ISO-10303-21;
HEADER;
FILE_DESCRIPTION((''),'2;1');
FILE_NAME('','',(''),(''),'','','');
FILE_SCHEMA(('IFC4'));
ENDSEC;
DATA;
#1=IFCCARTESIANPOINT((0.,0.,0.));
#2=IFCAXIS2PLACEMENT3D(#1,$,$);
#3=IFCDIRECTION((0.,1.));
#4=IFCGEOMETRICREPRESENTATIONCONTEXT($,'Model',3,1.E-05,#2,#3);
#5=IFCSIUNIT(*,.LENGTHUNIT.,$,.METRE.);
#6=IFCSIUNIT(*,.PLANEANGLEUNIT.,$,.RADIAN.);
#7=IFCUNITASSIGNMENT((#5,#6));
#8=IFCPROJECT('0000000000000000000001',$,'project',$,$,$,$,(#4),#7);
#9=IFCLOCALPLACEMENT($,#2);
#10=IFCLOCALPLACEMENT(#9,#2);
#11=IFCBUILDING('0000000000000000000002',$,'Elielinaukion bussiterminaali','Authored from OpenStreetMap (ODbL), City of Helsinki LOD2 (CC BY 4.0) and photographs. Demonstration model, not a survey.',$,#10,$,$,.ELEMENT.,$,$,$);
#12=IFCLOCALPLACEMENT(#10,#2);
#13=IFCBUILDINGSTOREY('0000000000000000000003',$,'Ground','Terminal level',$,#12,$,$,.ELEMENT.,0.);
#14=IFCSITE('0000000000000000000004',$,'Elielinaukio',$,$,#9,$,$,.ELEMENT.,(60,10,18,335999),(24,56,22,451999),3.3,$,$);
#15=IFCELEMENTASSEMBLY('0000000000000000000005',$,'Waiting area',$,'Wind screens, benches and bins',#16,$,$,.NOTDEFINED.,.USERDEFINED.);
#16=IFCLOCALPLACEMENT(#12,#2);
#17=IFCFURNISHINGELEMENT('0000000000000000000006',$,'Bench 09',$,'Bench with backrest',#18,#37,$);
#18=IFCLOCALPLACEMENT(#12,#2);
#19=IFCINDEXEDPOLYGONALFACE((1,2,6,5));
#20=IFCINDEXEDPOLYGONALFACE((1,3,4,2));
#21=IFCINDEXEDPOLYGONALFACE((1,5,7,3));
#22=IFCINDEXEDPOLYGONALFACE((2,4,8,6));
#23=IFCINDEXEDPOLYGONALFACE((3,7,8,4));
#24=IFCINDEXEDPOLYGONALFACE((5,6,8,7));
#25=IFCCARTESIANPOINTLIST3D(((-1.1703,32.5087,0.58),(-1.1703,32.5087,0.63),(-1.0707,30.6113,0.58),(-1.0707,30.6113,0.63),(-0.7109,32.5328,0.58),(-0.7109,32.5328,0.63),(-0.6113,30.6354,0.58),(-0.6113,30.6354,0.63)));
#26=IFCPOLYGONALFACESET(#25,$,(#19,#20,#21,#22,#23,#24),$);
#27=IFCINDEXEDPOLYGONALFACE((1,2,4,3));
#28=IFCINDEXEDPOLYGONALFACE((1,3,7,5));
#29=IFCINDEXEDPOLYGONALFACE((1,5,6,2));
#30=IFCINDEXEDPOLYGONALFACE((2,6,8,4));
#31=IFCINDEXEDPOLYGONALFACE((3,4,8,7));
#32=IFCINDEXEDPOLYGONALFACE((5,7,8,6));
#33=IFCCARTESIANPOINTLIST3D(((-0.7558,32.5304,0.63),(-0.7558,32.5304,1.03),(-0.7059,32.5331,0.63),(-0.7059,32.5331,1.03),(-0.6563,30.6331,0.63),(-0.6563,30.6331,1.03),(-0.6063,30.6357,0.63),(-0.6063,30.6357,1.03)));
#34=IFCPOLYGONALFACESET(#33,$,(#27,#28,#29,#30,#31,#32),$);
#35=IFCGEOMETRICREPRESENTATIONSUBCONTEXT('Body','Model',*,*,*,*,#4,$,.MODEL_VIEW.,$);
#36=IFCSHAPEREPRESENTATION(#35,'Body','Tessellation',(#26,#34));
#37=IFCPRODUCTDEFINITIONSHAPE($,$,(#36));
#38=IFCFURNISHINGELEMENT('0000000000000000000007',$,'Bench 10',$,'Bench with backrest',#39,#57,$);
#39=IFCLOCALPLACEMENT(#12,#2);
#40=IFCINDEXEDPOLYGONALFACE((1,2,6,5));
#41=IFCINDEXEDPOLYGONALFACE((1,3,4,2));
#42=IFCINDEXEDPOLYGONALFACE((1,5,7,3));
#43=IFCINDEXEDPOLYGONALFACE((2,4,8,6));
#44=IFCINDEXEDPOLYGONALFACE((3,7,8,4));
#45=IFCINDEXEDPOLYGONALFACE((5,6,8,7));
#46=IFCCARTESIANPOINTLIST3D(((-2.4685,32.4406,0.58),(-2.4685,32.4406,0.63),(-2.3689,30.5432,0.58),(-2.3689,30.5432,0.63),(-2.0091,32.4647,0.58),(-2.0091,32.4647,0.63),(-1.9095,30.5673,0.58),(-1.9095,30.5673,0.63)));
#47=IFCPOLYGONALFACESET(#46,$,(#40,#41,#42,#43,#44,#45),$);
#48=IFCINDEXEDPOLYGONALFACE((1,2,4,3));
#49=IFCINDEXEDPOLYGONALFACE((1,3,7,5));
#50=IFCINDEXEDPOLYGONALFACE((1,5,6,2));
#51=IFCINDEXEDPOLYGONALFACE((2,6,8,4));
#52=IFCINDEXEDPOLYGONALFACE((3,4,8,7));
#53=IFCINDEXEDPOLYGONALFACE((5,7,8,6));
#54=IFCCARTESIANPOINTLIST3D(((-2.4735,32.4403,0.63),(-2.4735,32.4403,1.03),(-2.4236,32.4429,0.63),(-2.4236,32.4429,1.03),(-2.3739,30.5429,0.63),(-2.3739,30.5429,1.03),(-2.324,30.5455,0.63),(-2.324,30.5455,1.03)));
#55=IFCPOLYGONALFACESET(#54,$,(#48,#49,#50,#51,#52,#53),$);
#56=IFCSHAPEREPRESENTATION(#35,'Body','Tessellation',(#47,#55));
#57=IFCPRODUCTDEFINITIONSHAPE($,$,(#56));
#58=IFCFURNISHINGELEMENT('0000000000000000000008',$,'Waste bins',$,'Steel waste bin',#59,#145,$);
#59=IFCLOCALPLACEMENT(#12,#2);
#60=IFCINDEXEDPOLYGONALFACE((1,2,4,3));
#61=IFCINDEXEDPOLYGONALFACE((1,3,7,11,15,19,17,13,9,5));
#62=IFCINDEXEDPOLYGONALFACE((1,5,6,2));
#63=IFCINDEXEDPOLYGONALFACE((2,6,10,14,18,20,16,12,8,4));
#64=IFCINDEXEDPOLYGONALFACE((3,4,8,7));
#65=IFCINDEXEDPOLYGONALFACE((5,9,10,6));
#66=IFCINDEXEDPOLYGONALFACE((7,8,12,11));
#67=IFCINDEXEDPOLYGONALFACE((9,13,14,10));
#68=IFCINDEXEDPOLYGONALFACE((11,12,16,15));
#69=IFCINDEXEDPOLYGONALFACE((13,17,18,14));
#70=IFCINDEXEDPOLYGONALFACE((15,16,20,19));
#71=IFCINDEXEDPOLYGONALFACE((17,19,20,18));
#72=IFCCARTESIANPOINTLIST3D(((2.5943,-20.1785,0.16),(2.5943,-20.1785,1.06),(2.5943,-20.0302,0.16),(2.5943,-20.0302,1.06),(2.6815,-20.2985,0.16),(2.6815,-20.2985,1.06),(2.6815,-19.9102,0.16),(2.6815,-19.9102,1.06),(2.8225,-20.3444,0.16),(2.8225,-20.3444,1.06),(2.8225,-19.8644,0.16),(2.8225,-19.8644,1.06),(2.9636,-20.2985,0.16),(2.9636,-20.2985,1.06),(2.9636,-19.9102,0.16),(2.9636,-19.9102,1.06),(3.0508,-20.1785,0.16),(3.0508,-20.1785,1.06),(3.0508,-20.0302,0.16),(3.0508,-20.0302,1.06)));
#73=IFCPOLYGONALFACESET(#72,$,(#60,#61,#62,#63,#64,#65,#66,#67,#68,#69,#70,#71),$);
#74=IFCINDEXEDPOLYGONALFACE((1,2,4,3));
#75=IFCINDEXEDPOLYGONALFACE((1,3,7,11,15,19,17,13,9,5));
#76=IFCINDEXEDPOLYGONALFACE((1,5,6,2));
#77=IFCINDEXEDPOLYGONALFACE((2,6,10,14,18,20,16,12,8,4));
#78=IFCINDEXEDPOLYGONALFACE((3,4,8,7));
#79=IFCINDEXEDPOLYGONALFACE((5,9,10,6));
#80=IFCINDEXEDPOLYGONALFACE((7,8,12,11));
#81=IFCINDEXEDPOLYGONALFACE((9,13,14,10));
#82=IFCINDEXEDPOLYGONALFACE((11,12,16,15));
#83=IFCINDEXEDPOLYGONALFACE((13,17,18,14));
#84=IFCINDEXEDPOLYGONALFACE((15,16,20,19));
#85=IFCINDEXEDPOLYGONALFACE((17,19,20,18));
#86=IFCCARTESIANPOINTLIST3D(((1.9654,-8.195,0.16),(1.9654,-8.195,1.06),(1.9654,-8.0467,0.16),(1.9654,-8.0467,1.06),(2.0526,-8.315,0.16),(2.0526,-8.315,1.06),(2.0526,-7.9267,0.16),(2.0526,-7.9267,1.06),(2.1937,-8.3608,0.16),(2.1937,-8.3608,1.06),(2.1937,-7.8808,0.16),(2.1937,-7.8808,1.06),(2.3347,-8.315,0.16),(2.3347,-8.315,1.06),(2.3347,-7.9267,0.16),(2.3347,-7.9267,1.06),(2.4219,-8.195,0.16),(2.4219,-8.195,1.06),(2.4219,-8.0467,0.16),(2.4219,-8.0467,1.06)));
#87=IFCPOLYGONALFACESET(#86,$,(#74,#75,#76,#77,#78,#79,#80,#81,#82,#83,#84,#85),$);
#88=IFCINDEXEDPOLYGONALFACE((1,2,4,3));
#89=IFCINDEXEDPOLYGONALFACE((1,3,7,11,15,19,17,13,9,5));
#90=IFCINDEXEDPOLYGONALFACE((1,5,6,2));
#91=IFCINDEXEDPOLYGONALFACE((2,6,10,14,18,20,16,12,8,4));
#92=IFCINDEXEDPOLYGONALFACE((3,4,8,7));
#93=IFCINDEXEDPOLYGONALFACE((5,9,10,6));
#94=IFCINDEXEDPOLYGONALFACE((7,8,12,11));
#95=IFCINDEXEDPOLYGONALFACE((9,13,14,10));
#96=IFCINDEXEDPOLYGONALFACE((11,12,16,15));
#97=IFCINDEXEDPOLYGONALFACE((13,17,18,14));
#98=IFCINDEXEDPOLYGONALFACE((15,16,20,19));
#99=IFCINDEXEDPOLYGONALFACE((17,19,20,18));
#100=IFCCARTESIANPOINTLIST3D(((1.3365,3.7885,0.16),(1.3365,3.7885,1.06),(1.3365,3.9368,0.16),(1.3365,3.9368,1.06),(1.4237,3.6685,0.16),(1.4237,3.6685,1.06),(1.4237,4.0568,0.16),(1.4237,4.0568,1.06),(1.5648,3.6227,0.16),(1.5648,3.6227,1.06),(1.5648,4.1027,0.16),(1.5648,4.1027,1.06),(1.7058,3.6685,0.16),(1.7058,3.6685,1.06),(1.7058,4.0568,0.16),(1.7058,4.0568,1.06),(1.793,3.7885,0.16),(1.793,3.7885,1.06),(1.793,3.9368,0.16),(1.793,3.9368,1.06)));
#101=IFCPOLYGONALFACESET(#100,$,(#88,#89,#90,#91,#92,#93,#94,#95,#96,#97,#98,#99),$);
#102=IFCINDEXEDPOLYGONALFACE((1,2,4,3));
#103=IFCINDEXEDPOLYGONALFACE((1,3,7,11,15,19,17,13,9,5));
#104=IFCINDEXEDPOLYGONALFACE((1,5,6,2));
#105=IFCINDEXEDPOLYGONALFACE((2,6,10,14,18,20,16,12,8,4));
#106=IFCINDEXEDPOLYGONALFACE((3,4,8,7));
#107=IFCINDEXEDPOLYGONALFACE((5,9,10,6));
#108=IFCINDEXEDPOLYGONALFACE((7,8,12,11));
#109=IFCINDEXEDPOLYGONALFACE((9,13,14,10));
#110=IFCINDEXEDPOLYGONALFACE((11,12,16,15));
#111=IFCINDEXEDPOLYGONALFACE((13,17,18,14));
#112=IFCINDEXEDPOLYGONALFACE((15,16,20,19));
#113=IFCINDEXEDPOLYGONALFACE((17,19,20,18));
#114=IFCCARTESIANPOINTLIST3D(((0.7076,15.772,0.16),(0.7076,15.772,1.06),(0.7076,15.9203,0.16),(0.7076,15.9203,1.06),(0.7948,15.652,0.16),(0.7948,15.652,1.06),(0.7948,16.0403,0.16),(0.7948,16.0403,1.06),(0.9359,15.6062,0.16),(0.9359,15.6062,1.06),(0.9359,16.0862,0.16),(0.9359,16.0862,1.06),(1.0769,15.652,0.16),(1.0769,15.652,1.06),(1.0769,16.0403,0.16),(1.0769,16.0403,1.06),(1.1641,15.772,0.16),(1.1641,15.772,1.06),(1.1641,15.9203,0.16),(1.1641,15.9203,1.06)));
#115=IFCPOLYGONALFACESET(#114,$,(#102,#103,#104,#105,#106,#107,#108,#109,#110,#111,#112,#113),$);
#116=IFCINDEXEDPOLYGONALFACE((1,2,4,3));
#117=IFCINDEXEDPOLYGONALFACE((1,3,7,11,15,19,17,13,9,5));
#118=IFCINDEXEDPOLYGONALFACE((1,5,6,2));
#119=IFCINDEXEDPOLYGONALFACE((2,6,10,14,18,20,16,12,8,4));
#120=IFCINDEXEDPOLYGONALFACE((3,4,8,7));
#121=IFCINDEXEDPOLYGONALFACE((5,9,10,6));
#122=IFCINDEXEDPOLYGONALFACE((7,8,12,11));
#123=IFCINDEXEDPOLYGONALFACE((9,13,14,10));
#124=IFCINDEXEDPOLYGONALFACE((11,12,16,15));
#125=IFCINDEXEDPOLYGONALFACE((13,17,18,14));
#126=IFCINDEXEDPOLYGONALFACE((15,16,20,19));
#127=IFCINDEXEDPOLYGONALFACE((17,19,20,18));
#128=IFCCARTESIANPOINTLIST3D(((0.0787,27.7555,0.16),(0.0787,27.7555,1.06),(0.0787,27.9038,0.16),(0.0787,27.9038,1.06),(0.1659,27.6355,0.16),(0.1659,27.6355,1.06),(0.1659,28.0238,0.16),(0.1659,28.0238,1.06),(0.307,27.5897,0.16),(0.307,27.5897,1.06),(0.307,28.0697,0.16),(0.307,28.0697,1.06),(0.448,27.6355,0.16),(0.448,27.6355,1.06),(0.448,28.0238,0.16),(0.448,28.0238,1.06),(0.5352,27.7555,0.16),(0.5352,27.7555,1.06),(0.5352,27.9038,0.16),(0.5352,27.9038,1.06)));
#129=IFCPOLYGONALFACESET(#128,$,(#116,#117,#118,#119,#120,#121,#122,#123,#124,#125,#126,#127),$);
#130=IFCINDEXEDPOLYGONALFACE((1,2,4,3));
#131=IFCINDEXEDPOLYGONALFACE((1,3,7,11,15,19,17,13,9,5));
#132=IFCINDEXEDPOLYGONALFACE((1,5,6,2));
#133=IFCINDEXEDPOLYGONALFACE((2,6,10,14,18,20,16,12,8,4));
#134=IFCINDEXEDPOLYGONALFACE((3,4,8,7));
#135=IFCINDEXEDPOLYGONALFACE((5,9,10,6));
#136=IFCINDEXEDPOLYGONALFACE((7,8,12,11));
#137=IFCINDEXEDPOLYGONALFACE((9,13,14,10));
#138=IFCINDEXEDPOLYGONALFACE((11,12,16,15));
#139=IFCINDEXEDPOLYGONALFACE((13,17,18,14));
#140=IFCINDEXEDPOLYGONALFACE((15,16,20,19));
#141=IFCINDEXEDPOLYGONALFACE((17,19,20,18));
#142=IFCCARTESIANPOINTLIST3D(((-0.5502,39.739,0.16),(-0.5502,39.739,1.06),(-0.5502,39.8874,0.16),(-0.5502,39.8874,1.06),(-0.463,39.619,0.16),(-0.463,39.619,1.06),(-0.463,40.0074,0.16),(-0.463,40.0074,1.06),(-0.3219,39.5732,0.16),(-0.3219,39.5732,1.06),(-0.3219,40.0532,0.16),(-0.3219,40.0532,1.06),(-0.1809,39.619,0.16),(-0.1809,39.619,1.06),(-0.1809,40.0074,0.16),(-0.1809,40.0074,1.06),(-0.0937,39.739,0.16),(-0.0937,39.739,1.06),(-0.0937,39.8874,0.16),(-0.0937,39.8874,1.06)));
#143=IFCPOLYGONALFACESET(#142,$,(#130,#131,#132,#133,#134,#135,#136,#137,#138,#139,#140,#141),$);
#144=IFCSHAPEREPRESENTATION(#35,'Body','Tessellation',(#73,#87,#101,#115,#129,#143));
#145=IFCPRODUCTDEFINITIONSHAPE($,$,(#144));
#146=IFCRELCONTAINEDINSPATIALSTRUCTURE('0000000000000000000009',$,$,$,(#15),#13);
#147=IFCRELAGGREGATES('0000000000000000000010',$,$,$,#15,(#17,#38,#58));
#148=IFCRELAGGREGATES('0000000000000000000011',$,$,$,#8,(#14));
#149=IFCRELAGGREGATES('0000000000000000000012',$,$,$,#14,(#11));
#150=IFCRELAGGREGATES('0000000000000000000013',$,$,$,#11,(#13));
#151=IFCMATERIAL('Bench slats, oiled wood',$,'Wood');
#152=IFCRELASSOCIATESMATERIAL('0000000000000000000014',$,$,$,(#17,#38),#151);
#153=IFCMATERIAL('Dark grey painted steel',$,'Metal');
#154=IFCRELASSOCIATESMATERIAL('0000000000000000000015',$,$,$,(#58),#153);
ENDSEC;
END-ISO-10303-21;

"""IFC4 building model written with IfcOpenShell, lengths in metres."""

from ifc_helpers import new_model, si_unit, direction, frame, frame_2d, origin, place, context, subcontext, project, spatial, polyline, rectangle, outline, extrude, material, element, aggregate, save


model = new_model("IFC4")

# Units and contexts
model_context = context("Model", 3, precision=1e-05, world=origin(), true_north=direction((0.0, 1.0)))
body_context = subcontext(model_context, "Body", "Model", "MODEL_VIEW")
ifc_project = project(units=[si_unit("LENGTHUNIT", "METRE"), si_unit("PLANEANGLEUNIT", "RADIAN")], contexts=[model_context])

# Site, building, storey
site_placement = place(None, origin())
site = spatial("IfcSite", under=ifc_project, at=site_placement, Name="Elielinaukio", CompositionType="ELEMENT", RefLatitude=(60, 10, 18, 335999), RefLongitude=(24, 56, 22, 451999), RefElevation=3.3)
building_placement = place(site_placement, origin())
building = spatial("IfcBuilding", under=site, at=building_placement, Name="Elielinaukion bussiterminaali", Description="Authored from OpenStreetMap (ODbL), City of Helsinki LOD2 (CC BY 4.0) and photographs. Demonstration model, not a survey.", CompositionType="ELEMENT")
storey_placement = place(building_placement, origin())
storey = spatial("IfcBuildingStorey", under=building, at=storey_placement, Name="Ground", Description="Terminal level", CompositionType="ELEMENT", Elevation=0.0)

# Element assembly
assembly_1_placement = place(building_placement, origin())
assembly_1 = element("IfcElementAssembly", 1, at=assembly_1_placement, inside=storey, Name="Waiting area", ObjectType="Wind screens, benches and bins", AssemblyPlace="NOTDEFINED", PredefinedType="USERDEFINED")
ifc_material_1 = material(Name="Dark grey painted steel", Category="Metal")

# Furnishing elements
ifc_material_2 = material(Name="Bench slats, oiled wood", Category="Wood")
furnishing_1_placement = place(building_placement, origin())
furnishing_1 = element("IfcFurnishingElement", 2, at=furnishing_1_placement, material=ifc_material_2, Name="Bench 09", ObjectType="Bench with backrest", context=body_context, shape_type="SweptSolid", body=[
    extrude(rectangle(XDim=1.9, YDim=0.46, at=frame_2d((0.0, 0.0), x_axis=(-0.052408, 0.998626))), frame((-0.8908, 31.5721, 0.58)), (0.0, 0.0, 1.0), 0.05),
    extrude(rectangle(XDim=1.9, YDim=0.05, at=frame_2d((0.0, 0.0), x_axis=(-0.052408, 0.998626))), frame((-0.6811, 31.5831, 0.63)), (0.0, 0.0, 1.0), 0.4),
])
furnishing_2_placement = place(building_placement, origin())
furnishing_2 = element("IfcFurnishingElement", 3, at=furnishing_2_placement, material=ifc_material_2, Name="Bench 10", ObjectType="Bench with backrest", context=body_context, shape_type="SweptSolid", body=[
    extrude(rectangle(XDim=1.9, YDim=0.46, at=frame_2d((0.0, 0.0), x_axis=(-0.052408, 0.998626))), frame((-2.189, 31.5039, 0.58)), (0.0, 0.0, 1.0), 0.05),
    extrude(rectangle(XDim=1.9, YDim=0.05, at=frame_2d((0.0, 0.0), x_axis=(-0.052408, 0.998626))), frame((-2.3987, 31.4929, 0.63)), (0.0, 0.0, 1.0), 0.4),
])
furnishing_3_placement = place(building_placement, origin())
furnishing_3 = element("IfcFurnishingElement", 4, at=furnishing_3_placement, material=ifc_material_1, Name="Waste bins", ObjectType="Steel waste bin", context=body_context, shape_type="SweptSolid", body=[
    extrude(outline(polyline([(3.0508, -20.0302), (2.9636, -19.9102), (2.8225, -19.8644), (2.6815, -19.9102), (2.5943, -20.0302), (2.5943, -20.1785), (2.6815, -20.2985), (2.8225, -20.3444), (2.9636, -20.2985), (3.0508, -20.1785), (3.0508, -20.0302)])), frame((0.0, 0.0, 0.16)), (0.0, 0.0, 1.0), 0.9),
    extrude(outline(polyline([(2.4219, -8.0467), (2.3347, -7.9267), (2.1937, -7.8808), (2.0526, -7.9267), (1.9654, -8.0467), (1.9654, -8.195), (2.0526, -8.315), (2.1937, -8.3608), (2.3347, -8.315), (2.4219, -8.195), (2.4219, -8.0467)])), frame((0.0, 0.0, 0.16)), (0.0, 0.0, 1.0), 0.9),
    extrude(outline(polyline([(1.793, 3.9368), (1.7058, 4.0568), (1.5648, 4.1027), (1.4237, 4.0568), (1.3365, 3.9368), (1.3365, 3.7885), (1.4237, 3.6685), (1.5648, 3.6227), (1.7058, 3.6685), (1.793, 3.7885), (1.793, 3.9368)])), frame((0.0, 0.0, 0.16)), (0.0, 0.0, 1.0), 0.9),
    extrude(outline(polyline([(1.1641, 15.9203), (1.0769, 16.0403), (0.9359, 16.0862), (0.7948, 16.0403), (0.7076, 15.9203), (0.7076, 15.772), (0.7948, 15.652), (0.9359, 15.6062), (1.0769, 15.652), (1.1641, 15.772), (1.1641, 15.9203)])), frame((0.0, 0.0, 0.16)), (0.0, 0.0, 1.0), 0.9),
    extrude(outline(polyline([(0.5352, 27.9038), (0.448, 28.0238), (0.307, 28.0697), (0.1659, 28.0238), (0.0787, 27.9038), (0.0787, 27.7555), (0.1659, 27.6355), (0.307, 27.5897), (0.448, 27.6355), (0.5352, 27.7555), (0.5352, 27.9038)])), frame((0.0, 0.0, 0.16)), (0.0, 0.0, 1.0), 0.9),
    extrude(outline(polyline([(-0.0937, 39.8874), (-0.1809, 40.0074), (-0.3219, 40.0532), (-0.463, 40.0074), (-0.5502, 39.8874), (-0.5502, 39.739), (-0.463, 39.619), (-0.3219, 39.5732), (-0.1809, 39.619), (-0.0937, 39.739), (-0.0937, 39.8874)])), frame((0.0, 0.0, 0.16)), (0.0, 0.0, 1.0), 0.9),
])
aggregate(assembly_1, [furnishing_1, furnishing_2, furnishing_3])

save(model, "model.ifc")
